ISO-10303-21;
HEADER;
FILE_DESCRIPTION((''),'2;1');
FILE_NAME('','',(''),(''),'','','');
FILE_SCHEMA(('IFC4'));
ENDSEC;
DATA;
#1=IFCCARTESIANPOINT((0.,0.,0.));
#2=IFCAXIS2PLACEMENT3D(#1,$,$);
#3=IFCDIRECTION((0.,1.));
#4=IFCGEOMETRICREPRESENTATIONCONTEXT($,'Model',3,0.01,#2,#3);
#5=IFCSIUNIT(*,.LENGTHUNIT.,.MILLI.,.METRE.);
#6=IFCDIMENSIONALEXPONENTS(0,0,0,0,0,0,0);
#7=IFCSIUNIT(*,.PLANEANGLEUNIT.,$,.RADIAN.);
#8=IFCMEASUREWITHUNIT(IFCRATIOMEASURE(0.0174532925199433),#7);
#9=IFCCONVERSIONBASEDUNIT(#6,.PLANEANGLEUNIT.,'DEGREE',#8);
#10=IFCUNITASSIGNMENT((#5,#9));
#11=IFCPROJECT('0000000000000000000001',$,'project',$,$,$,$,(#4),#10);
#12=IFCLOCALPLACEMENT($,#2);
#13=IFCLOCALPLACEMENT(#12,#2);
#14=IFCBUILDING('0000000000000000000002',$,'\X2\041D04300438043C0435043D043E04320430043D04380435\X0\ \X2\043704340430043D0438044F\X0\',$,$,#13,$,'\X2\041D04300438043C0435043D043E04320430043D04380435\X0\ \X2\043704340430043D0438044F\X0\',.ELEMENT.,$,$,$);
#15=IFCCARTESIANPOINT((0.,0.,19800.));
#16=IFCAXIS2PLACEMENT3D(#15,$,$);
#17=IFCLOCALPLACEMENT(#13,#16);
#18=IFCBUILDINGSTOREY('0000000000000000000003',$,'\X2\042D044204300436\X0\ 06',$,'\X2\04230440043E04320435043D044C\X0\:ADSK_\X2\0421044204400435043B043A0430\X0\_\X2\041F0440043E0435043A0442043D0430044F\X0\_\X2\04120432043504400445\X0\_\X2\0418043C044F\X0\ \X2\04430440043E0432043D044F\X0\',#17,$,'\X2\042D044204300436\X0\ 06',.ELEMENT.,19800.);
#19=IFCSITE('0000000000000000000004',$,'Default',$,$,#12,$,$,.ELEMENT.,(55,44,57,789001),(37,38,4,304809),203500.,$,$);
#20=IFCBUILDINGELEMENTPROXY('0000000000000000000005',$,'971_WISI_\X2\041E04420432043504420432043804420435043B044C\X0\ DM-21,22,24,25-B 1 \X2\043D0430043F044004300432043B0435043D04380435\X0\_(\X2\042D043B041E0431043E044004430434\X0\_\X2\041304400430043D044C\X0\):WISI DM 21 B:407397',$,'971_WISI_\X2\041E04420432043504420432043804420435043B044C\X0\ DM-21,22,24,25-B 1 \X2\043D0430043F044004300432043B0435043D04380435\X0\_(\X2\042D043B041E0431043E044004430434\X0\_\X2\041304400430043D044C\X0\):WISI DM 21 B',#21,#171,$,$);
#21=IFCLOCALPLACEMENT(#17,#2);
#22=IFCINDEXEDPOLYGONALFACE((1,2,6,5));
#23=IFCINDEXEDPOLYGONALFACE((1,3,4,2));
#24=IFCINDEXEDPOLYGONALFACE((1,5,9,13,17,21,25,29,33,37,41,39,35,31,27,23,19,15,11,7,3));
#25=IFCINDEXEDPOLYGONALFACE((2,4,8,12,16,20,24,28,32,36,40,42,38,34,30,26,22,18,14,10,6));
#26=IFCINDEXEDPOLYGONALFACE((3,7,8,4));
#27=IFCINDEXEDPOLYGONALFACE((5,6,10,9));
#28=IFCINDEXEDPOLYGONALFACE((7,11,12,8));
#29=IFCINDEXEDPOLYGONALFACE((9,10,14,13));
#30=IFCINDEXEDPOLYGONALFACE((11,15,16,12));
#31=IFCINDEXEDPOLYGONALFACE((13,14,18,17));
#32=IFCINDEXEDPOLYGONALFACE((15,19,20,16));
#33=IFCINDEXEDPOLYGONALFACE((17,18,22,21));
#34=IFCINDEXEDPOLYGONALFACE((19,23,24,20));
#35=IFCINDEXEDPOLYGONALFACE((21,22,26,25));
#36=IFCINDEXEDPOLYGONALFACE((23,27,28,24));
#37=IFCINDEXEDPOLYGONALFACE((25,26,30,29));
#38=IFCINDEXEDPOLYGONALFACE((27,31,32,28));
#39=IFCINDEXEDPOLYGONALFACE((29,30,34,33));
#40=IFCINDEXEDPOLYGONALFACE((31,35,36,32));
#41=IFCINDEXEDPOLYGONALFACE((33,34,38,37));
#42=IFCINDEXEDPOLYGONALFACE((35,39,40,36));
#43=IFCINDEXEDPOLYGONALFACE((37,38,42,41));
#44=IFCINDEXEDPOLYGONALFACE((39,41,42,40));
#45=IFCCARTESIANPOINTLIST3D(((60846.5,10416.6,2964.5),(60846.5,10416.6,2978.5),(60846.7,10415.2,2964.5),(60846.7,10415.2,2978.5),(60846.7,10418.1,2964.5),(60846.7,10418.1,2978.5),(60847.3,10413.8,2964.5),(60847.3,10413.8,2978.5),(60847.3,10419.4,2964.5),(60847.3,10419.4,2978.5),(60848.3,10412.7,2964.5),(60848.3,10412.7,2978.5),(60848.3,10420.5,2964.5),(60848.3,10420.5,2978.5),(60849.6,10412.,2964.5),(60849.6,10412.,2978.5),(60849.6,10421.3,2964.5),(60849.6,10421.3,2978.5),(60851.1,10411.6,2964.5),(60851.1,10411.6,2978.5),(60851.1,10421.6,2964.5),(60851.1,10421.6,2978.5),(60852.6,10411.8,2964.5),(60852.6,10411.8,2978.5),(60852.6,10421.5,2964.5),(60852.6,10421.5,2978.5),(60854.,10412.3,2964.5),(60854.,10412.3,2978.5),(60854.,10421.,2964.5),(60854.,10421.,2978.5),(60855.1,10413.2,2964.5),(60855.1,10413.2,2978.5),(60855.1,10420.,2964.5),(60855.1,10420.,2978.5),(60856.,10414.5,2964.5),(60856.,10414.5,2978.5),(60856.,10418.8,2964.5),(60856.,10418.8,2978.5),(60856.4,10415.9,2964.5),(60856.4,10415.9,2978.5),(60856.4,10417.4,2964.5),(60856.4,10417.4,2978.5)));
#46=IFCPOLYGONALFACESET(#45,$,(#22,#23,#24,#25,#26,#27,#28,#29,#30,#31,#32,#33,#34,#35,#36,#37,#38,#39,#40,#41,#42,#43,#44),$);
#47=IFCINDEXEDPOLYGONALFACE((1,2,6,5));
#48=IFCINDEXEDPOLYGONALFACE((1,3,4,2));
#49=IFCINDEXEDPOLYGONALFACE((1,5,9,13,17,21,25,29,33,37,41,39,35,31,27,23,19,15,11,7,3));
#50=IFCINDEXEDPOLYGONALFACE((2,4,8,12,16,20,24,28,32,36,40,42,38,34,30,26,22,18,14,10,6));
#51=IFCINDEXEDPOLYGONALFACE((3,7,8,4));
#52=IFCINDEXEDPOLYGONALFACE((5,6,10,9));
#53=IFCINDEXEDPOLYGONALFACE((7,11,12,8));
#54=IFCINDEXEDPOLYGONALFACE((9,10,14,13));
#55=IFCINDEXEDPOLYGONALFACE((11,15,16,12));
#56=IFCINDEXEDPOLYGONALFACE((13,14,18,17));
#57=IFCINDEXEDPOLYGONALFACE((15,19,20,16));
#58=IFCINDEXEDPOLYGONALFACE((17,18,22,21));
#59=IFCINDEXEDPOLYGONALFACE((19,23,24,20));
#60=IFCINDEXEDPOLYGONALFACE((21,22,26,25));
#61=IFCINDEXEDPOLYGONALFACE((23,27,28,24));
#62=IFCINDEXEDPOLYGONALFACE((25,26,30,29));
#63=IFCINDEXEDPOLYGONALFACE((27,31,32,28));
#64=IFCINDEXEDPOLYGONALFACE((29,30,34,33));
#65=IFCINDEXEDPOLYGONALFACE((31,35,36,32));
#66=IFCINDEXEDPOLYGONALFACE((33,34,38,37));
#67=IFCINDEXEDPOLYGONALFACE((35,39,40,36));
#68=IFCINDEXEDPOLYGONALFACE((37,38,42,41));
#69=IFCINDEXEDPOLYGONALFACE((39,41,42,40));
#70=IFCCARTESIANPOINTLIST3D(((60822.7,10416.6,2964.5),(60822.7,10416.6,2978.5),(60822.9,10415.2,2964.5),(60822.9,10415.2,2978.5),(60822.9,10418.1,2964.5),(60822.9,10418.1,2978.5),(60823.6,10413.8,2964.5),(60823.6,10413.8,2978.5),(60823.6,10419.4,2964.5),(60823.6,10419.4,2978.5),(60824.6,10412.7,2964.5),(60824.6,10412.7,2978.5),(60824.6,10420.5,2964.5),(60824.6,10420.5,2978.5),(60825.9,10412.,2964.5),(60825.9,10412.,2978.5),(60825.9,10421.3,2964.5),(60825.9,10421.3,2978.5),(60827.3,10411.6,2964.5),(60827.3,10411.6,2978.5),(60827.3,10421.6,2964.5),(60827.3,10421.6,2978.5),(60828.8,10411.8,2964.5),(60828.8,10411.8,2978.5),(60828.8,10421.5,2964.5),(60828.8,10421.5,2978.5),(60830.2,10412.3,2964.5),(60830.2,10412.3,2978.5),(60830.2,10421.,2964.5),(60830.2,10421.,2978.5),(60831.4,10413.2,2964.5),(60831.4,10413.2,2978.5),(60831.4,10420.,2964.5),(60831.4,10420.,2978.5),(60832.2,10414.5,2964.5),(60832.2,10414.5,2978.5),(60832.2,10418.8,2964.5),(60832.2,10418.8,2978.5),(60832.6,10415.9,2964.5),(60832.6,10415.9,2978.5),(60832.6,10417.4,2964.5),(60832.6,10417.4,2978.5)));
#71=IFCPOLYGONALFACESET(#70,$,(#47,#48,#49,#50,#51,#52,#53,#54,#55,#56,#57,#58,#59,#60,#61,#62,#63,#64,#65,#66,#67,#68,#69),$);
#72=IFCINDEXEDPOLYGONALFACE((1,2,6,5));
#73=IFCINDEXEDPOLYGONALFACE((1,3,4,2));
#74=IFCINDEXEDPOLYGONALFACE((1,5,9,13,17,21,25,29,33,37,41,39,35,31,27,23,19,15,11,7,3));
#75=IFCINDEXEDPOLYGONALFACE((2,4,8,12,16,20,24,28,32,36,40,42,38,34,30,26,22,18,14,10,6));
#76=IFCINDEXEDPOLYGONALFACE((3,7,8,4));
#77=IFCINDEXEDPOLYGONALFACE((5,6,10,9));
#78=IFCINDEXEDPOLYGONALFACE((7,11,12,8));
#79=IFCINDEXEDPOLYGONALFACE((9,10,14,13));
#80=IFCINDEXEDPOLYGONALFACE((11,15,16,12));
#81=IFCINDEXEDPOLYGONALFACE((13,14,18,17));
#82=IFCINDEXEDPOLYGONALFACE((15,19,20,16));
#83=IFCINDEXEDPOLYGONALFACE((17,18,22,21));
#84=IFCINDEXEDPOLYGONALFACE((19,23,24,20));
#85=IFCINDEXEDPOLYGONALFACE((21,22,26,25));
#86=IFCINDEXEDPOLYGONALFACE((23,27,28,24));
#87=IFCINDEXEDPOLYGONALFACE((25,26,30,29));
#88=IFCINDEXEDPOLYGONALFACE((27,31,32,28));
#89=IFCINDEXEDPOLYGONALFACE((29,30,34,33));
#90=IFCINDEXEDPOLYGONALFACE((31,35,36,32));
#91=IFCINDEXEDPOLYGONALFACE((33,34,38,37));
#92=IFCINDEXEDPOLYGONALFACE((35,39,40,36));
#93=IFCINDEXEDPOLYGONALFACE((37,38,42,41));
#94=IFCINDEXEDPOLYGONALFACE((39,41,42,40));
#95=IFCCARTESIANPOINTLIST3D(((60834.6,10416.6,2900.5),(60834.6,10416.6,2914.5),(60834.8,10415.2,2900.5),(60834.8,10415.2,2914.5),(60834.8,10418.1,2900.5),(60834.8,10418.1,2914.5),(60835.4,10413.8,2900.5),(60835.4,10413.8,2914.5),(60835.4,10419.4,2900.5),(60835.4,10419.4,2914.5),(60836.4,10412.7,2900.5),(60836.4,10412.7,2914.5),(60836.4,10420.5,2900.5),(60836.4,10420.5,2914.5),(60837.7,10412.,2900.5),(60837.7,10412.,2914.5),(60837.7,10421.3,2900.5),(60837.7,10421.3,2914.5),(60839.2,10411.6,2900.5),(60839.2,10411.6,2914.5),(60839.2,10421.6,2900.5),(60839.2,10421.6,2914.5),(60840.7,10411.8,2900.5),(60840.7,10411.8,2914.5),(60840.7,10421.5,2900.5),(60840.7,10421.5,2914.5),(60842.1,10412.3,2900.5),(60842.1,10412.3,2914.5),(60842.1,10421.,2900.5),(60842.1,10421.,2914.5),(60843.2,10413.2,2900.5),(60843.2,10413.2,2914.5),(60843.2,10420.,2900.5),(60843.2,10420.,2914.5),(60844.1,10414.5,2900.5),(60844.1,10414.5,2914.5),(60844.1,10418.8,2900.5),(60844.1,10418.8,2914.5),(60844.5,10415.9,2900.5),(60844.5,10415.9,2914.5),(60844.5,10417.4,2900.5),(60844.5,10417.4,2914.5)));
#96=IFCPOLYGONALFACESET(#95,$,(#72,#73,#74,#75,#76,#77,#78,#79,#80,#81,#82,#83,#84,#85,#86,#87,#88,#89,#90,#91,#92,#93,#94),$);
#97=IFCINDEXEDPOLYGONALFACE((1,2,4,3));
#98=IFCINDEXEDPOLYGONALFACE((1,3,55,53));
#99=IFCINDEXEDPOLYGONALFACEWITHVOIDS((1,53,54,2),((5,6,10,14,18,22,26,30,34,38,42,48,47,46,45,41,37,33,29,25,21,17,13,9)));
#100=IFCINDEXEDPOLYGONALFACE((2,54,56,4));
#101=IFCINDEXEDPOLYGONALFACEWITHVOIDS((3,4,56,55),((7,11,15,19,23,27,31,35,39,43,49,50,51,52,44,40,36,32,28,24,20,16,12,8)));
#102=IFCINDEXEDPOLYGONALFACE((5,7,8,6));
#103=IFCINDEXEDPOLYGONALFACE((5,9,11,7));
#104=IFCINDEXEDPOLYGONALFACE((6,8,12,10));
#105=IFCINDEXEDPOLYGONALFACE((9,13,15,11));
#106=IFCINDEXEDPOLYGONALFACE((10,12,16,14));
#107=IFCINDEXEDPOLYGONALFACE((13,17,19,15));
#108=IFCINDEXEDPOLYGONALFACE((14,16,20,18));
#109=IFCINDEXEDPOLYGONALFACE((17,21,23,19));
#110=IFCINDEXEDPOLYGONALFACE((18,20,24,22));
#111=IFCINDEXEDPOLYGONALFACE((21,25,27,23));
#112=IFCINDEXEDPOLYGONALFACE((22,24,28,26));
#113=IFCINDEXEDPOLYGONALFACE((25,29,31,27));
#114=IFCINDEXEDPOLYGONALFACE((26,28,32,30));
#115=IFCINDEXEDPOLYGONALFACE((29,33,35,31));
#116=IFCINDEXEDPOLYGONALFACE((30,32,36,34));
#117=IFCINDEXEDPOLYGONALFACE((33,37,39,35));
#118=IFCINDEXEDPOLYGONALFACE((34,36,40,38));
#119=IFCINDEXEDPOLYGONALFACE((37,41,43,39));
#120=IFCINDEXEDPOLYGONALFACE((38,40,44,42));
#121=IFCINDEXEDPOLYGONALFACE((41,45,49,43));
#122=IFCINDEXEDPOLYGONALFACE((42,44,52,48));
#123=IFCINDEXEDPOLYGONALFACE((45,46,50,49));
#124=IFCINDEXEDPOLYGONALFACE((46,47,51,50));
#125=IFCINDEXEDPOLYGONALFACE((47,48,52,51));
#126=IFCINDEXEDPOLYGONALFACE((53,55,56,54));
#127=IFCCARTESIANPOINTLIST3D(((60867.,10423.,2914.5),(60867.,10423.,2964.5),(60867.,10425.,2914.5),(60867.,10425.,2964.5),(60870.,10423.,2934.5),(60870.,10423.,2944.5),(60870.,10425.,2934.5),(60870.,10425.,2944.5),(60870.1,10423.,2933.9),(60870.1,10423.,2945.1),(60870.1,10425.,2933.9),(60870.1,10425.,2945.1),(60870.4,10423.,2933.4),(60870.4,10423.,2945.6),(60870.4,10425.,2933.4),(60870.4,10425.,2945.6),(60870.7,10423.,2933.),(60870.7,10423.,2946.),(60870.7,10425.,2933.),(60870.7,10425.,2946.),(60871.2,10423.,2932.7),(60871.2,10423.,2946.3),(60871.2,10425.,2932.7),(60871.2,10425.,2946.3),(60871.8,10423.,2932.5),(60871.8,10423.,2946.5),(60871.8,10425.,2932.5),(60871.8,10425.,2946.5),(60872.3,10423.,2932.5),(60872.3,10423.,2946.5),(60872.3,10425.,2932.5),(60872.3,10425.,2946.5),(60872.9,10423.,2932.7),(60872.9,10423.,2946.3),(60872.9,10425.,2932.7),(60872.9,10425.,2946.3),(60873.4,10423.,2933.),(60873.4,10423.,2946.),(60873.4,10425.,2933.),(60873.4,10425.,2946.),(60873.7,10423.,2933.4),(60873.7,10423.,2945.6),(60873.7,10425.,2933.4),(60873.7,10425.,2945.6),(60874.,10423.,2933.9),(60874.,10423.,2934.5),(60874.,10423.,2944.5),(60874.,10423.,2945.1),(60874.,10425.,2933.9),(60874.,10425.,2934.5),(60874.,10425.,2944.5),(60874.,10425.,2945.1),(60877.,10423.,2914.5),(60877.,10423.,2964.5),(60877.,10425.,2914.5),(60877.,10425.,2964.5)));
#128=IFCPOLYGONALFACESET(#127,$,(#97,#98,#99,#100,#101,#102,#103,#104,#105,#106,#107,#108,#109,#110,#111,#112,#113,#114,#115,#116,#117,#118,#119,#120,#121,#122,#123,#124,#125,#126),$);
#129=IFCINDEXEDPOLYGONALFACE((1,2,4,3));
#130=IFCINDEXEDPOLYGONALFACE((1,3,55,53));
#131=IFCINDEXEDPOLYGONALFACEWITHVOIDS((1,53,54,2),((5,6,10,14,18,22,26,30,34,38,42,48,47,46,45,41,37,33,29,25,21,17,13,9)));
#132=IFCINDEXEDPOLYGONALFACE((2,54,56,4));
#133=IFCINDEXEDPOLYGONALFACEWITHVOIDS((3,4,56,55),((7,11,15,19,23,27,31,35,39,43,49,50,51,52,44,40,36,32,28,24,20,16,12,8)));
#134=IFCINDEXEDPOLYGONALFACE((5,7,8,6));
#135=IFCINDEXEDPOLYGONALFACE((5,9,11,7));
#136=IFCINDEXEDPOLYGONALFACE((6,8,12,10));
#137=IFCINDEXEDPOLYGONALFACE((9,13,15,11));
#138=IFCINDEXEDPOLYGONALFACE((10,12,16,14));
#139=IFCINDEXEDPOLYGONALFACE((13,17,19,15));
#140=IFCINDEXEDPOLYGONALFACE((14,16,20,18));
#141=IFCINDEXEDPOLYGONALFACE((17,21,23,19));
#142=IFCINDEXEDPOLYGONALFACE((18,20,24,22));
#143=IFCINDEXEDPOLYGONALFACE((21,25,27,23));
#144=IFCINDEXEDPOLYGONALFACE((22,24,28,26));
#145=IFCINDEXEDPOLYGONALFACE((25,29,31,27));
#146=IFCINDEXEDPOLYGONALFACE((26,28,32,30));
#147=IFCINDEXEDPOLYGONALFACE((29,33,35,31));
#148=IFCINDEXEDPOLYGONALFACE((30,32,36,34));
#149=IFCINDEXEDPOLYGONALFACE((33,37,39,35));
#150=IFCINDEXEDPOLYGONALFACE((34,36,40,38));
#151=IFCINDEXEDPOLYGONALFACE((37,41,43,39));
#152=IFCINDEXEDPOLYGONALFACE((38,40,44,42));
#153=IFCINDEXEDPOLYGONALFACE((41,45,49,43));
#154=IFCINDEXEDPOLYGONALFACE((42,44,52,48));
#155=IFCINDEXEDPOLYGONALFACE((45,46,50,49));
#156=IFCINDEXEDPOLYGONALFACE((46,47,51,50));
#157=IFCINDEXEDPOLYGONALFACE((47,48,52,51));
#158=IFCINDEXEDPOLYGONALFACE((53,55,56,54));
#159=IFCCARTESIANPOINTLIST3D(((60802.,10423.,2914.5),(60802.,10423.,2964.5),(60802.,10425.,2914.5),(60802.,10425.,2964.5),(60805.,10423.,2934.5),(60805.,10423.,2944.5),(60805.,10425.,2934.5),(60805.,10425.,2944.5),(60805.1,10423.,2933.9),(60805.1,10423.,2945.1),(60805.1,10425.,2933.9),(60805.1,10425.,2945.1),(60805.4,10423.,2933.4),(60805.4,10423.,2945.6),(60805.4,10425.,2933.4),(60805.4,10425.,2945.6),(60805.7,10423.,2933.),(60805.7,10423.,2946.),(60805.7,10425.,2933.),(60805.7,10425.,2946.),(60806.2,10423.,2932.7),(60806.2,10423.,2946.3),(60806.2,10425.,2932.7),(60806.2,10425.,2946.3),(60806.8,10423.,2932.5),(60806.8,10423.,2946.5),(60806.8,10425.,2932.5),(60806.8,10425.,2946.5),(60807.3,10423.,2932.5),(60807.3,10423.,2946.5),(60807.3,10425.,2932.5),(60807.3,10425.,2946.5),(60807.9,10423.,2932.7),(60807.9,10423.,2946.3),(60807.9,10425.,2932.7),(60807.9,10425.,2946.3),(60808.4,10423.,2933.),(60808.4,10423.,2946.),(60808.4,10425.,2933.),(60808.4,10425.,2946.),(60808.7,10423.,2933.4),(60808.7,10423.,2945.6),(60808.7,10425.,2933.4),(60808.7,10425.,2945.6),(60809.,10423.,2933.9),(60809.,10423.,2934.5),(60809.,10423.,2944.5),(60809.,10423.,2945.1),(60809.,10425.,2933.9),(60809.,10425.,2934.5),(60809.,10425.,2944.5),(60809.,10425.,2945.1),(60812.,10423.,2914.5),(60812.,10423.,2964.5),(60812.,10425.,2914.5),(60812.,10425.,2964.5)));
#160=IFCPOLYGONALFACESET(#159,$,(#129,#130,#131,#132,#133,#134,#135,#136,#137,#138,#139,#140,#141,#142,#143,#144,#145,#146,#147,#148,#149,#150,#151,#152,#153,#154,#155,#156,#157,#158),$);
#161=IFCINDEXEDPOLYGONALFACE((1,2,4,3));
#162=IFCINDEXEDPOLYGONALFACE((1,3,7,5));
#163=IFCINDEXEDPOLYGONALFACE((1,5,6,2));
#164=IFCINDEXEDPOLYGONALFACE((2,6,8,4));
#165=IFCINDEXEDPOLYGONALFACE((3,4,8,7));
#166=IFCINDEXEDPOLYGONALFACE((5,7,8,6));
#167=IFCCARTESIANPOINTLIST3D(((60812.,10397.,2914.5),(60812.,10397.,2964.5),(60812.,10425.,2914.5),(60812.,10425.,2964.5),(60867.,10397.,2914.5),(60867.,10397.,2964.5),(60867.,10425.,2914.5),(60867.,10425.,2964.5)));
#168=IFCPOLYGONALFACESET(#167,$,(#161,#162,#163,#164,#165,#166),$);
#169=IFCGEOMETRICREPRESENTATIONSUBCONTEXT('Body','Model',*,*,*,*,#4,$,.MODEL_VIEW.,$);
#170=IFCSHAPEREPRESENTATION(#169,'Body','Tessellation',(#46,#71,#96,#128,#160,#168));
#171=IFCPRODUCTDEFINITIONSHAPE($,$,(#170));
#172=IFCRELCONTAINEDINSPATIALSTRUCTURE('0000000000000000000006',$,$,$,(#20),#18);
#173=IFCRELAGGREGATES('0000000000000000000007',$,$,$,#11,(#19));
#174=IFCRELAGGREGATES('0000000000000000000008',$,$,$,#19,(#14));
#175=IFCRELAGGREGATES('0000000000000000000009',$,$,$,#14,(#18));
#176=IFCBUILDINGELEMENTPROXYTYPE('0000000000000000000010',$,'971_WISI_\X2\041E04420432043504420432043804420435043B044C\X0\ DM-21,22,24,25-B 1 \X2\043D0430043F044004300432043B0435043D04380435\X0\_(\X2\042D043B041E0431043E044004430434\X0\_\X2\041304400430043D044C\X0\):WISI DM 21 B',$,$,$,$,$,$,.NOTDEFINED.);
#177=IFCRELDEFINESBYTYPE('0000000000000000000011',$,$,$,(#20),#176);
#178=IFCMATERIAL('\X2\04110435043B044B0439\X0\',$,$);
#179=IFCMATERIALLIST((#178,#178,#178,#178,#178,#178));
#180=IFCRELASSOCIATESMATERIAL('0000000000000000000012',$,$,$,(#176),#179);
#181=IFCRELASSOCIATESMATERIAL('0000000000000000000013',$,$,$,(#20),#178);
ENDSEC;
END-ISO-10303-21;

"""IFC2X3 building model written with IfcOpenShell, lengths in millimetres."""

from ifc_helpers import new_model, entity, si_unit, converted_unit, direction, frame, frame_2d, origin, place, context, subcontext, project, spatial, polyline, circle_curve, parameter, trimmed, segment, composite_curve, rectangle, circle, outline, extrude, source, transform, mapped, material, material_list, type_object, type_shapes, element, save


model = new_model("IFC2X3")

# Units and contexts
model_context = context("Model", 3, precision=0.01, world=origin(), true_north=direction((0.0, 1.0)))
body_context = subcontext(model_context, "Body", "Model", "MODEL_VIEW")
ifc_project = project(units=[si_unit("LENGTHUNIT", "METRE", prefix="MILLI"), converted_unit("PLANEANGLEUNIT", "DEGREE", entity("IfcRatioMeasure", 0.0174532925199433), si_unit("PLANEANGLEUNIT", "RADIAN"), dimensions=[0, 0, 0, 0, 0, 0, 0])], contexts=[model_context])

# Site, building, storey
site_placement = place(None, frame((0.0, 0.0, 0.0)))
site = spatial("IfcSite", under=ifc_project, at=site_placement, Name="Default", CompositionType="ELEMENT", RefLatitude=(55, 44, 57, 789001), RefLongitude=(37, 38, 4, 304809), RefElevation=203500.0)
building_placement = place(site_placement, origin())
building = spatial("IfcBuilding", under=site, at=building_placement, Name="Наименование здания", LongName="Наименование здания", CompositionType="ELEMENT")
storey_placement = place(building_placement, frame((0.0, 0.0, 19800.0)))
storey = spatial("IfcBuildingStorey", under=building, at=storey_placement, Name="Этаж 06", ObjectType="Уровень:ADSK_Стрелка_Проектная_Вверх_Имя уровня", LongName="Этаж 06", CompositionType="ELEMENT", Elevation=19800.0)

# Building element proxy
ifc_material_1 = material(Name="Белый")
ifc_material_list_1 = material_list([ifc_material_1, ifc_material_1, ifc_material_1, ifc_material_1, ifc_material_1, ifc_material_1])
building_element_proxy_type_1 = type_object("IfcBuildingElementProxyType", Name="971_WISI_Ответвитель DM-21,22,24,25-B 1 направление_(ЭлОборуд_Грань):WISI DM 21 B", PredefinedType="NOTDEFINED", material=ifc_material_list_1)
shared_shape_1 = source(origin(), body_context, "Body", "SweptSolid", [
    extrude(circle(Radius=5.0, at=frame_2d((0.0, 0.0), x_axis=(1.0, 0.0))), frame((11.9, 25.0, 8.4), z_axis=(0.0, 1.0, 0.0), x_axis=(-1.0, 0.0, 0.0)), (0.0, 0.0, 1.0), 14.0),
    extrude(circle(Radius=5.0, at=frame_2d((0.0, 0.0), x_axis=(1.0, 0.0))), frame((-11.8, 25.0, 8.4), z_axis=(0.0, 1.0, 0.0), x_axis=(-1.0, 0.0, 0.0)), (0.0, 0.0, 1.0), 14.0),
    extrude(circle(Radius=5.0, at=frame_2d((0.0, 0.0), x_axis=(1.0, 0.0))), frame((0.0, -39.0, 8.4), z_axis=(0.0, 1.0, 0.0), x_axis=(-1.0, 0.0, 0.0)), (0.0, 0.0, 1.0), 14.0),
    extrude(outline(polyline([(-5.0, -25.0), (5.0, -25.0), (5.0, 25.0), (-5.0, 25.0), (-5.0, -25.0)]), holes=[composite_curve([segment(polyline([(2.0, 5.0), (2.0, -5.0)]), True, "CONTINUOUS"), segment(trimmed(circle_curve(frame_2d((0.0, -5.0), x_axis=(-1.0, 0.0)), 2.0), [parameter(0.0)], [parameter(180.0)], True, "PARAMETER"), False, "CONTINUOUS"), segment(polyline([(-2.0, -5.0), (-2.0, 5.0)]), True, "CONTINUOUS"), segment(trimmed(circle_curve(frame_2d((0.0, 5.0), x_axis=(-1.0, 0.0)), 2.0), [parameter(180.0)], [parameter(0.0)], True, "PARAMETER"), False, "CONTINUOUS")], self_intersect=False)]), frame((32.5, 0.0, 0.0), z_axis=(0.0, 0.0, 1.0), x_axis=(-1.0, 0.0, 0.0)), (0.0, 0.0, 1.0), 2.0),
    extrude(outline(polyline([(-5.0, -25.0), (5.0, -25.0), (5.0, 25.0), (-5.0, 25.0), (-5.0, -25.0)]), holes=[composite_curve([segment(polyline([(-2.0, -5.0), (-2.0, 5.0)]), True, "CONTINUOUS"), segment(trimmed(circle_curve(frame_2d((0.0, 5.0), x_axis=(-1.0, 0.0)), 2.0), [parameter(180.0)], [parameter(0.0)], True, "PARAMETER"), False, "CONTINUOUS"), segment(polyline([(2.0, 5.0), (2.0, -5.0)]), True, "CONTINUOUS"), segment(trimmed(circle_curve(frame_2d((0.0, -5.0), x_axis=(-1.0, 0.0)), 2.0), [parameter(0.0)], [parameter(180.0)], True, "PARAMETER"), False, "CONTINUOUS")], self_intersect=False)]), frame((-32.5, 0.0, 0.0), z_axis=(0.0, 0.0, 1.0), x_axis=(-1.0, 0.0, 0.0)), (0.0, 0.0, 1.0), 2.0),
    extrude(rectangle(XDim=55.0, YDim=50.0, at=frame_2d((0.0, 0.0), x_axis=(1.0, 0.0))), frame((0.0, 0.0, 0.0), z_axis=(0.0, 0.0, 1.0), x_axis=(-1.0, 0.0, 0.0)), (0.0, 0.0, 1.0), 28.0),
])
type_shapes(building_element_proxy_type_1, [shared_shape_1])
for number, where, z_axis, x_axis, name in (
    (1, (60839.5, 10425.0, 2939.5), (0.0, -1.0, 0.0), (1.0, 0.0, 0.0), "971_WISI_Ответвитель DM-21,22,24,25-B 1 направление_(ЭлОборуд_Грань):WISI DM 21 B:407397"),
):
    element("IfcBuildingElementProxy", number, at=place(storey_placement, frame(where, z_axis=z_axis, x_axis=x_axis)), inside=storey, type_object=building_element_proxy_type_1, material=ifc_material_1, Name=name, ObjectType="971_WISI_Ответвитель DM-21,22,24,25-B 1 направление_(ЭлОборуд_Грань):WISI DM 21 B", context=body_context, shape_type="MappedRepresentation", body=[
        mapped(shared_shape_1, transform((0.0, 0.0, 0.0), scale=1.0)),
    ])

save(model, "model.ifc")
